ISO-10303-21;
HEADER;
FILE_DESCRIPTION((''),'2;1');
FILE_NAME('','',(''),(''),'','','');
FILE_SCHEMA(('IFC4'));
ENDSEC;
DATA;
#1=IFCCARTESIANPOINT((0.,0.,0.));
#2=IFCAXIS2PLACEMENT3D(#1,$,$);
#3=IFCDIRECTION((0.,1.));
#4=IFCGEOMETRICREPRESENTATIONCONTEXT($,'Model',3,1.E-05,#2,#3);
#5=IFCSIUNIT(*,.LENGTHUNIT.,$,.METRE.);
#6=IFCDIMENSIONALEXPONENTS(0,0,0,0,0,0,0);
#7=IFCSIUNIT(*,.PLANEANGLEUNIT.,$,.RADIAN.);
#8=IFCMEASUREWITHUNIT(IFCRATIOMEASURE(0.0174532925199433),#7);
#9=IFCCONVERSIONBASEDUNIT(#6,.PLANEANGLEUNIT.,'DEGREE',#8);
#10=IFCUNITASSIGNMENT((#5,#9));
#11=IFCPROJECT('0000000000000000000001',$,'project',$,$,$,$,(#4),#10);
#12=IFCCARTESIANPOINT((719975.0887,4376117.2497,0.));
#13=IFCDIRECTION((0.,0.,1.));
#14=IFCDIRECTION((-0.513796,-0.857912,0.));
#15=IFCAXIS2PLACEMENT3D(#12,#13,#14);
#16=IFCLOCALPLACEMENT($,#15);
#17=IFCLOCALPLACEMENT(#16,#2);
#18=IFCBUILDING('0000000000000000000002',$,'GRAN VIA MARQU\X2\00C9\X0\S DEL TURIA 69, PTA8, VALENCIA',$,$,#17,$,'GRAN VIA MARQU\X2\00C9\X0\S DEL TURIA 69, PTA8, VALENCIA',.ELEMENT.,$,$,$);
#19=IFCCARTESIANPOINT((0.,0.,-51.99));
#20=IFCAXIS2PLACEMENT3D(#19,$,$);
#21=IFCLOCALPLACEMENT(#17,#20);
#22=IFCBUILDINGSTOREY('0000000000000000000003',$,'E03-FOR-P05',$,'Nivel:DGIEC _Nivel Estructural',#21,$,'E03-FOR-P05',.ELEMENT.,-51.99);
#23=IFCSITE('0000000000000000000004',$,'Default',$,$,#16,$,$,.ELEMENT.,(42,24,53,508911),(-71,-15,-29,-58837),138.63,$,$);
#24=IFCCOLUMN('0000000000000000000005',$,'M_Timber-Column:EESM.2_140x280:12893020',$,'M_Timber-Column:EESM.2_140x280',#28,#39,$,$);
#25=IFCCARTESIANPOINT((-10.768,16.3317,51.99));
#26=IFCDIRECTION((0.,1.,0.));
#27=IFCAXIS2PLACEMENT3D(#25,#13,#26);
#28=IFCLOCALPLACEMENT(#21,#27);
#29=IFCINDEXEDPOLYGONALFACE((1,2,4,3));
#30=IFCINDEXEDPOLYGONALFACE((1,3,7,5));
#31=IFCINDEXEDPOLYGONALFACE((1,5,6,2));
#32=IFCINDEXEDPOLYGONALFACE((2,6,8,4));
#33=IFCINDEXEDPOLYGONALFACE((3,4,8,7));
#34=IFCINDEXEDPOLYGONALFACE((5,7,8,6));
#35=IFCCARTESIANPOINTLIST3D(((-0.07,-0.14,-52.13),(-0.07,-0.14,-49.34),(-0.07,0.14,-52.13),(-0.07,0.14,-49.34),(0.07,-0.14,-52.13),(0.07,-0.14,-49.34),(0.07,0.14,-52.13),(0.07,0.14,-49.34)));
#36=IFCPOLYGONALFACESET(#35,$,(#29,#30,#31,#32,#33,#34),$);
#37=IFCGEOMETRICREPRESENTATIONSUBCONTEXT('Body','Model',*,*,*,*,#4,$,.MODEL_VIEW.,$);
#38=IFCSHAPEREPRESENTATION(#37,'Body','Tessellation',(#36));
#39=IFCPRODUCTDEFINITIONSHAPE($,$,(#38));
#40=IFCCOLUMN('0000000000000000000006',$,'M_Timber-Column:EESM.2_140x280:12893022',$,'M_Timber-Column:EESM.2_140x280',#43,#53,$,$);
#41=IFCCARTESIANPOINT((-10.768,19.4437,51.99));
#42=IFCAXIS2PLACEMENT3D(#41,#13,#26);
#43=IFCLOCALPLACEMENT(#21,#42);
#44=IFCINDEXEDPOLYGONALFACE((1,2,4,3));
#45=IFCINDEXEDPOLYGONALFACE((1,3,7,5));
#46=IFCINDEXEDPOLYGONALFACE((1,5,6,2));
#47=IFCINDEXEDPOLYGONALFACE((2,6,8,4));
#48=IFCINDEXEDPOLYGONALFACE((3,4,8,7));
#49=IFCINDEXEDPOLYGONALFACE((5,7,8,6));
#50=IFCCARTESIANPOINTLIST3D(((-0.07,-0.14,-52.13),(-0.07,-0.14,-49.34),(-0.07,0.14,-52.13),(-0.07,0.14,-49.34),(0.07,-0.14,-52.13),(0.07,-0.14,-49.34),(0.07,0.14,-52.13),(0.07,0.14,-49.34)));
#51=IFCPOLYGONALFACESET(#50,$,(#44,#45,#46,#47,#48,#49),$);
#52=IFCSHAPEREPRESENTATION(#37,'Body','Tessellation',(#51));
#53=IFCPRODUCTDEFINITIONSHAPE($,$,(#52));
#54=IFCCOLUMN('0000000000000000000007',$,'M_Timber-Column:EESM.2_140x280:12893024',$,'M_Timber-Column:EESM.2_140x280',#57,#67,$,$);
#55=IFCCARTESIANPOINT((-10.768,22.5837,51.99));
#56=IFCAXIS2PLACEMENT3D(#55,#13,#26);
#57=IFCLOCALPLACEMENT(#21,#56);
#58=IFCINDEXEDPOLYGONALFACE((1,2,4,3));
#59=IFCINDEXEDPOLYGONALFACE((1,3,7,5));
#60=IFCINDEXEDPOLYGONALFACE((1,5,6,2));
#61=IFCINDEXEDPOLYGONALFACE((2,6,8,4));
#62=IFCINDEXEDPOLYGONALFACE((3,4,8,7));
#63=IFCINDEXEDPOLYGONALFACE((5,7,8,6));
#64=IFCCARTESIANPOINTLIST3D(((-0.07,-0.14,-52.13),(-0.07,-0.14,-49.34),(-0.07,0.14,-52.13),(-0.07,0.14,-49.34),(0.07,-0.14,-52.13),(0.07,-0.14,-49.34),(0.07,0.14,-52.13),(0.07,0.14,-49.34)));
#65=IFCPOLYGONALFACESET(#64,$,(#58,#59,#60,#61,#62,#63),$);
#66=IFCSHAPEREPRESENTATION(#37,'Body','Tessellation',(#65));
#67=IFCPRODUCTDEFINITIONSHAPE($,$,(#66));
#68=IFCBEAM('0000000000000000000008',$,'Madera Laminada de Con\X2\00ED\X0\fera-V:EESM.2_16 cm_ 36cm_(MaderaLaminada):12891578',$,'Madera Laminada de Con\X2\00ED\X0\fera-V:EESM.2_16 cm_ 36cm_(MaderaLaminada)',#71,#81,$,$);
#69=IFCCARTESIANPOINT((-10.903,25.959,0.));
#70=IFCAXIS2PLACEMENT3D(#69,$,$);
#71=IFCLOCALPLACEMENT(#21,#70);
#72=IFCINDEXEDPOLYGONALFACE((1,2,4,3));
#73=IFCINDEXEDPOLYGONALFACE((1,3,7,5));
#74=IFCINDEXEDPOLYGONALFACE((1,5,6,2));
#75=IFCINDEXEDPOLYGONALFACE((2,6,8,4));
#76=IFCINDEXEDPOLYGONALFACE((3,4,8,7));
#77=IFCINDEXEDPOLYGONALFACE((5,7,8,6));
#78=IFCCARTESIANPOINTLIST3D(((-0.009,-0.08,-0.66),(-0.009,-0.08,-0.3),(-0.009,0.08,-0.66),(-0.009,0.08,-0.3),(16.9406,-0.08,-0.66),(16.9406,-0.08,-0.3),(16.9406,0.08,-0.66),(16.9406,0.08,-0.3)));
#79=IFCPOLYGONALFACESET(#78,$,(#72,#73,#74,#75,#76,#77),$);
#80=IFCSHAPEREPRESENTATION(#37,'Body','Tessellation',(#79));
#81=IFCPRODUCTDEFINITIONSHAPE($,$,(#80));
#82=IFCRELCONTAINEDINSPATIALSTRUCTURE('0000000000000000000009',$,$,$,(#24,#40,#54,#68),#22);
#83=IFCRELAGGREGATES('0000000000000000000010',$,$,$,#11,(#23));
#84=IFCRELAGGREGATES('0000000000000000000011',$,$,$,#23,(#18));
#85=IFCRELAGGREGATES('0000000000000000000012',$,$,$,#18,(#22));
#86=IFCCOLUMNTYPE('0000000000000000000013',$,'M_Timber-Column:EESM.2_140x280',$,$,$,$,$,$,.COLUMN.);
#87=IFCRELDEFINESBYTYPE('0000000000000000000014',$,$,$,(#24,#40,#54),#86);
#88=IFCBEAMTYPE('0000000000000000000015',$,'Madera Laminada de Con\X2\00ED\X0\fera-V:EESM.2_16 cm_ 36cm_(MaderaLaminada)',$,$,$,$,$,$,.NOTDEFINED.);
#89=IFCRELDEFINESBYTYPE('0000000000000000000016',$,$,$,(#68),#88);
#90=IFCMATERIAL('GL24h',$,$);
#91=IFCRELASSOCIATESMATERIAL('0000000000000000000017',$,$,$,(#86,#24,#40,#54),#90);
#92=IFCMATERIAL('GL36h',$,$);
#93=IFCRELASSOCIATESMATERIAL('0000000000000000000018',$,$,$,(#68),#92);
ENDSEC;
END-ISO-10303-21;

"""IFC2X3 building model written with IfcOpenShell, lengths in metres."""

from ifc_helpers import new_model, entity, si_unit, converted_unit, direction, frame, frame_2d, origin, origin_2d_with_axis, place, context, subcontext, project, spatial, rectangle, extrude, source, transform, mapped, material, type_object, type_shapes, element, save


model = new_model("IFC2X3")

# Units and contexts
model_context = context("Model", 3, precision=1e-05, world=origin(), true_north=direction((0.0, 1.0)))
body_context = subcontext(model_context, "Body", "Model", "MODEL_VIEW")
ifc_project = project(units=[si_unit("LENGTHUNIT", "METRE"), converted_unit("PLANEANGLEUNIT", "DEGREE", entity("IfcRatioMeasure", 0.0174532925199433), si_unit("PLANEANGLEUNIT", "RADIAN"), dimensions=[0, 0, 0, 0, 0, 0, 0])], contexts=[model_context])

# Site, building, storey
site_placement = place(None, frame((719975.0887, 4376117.2497, 0.0), z_axis=(0.0, 0.0, 1.0), x_axis=(-0.513796, -0.857912, 0.0)))
site = spatial("IfcSite", under=ifc_project, at=site_placement, Name="Default", CompositionType="ELEMENT", RefLatitude=(42, 24, 53, 508911), RefLongitude=(-71, -15, -29, -58837), RefElevation=138.63)
building_placement = place(site_placement, origin())
building = spatial("IfcBuilding", under=site, at=building_placement, Name="GRAN VIA MARQUÉS DEL TURIA 69, PTA8, VALENCIA", LongName="GRAN VIA MARQUÉS DEL TURIA 69, PTA8, VALENCIA", CompositionType="ELEMENT")
storey_placement = place(building_placement, frame((0.0, 0.0, -51.99)))
storey = spatial("IfcBuildingStorey", under=building, at=storey_placement, Name="E03-FOR-P05", ObjectType="Nivel:DGIEC _Nivel Estructural", LongName="E03-FOR-P05", CompositionType="ELEMENT", Elevation=-51.99)

# Columns
ifc_material_1 = material(Name="GL24h")
column_type_1 = type_object("IfcColumnType", Name="M_Timber-Column:EESM.2_140x280", PredefinedType="COLUMN", material=ifc_material_1)
shared_shape_1 = source(origin(), body_context, "Body", "SweptSolid", [
    extrude(rectangle(XDim=0.28, YDim=0.14, at=origin_2d_with_axis()), frame((0.0, 0.0, -52.13), z_axis=(0.0, 0.0, 1.0), x_axis=(0.0, -1.0, 0.0)), (0.0, 0.0, 1.0), 2.79),
])
type_shapes(column_type_1, [shared_shape_1])
for number, where, z_axis, x_axis, name in (
    (1, (-10.768, 16.3317, 51.99), (0.0, 0.0, 1.0), (0.0, 1.0, 0.0), "M_Timber-Column:EESM.2_140x280:12893020"),
    (2, (-10.768, 19.4437, 51.99), (0.0, 0.0, 1.0), (0.0, 1.0, 0.0), "M_Timber-Column:EESM.2_140x280:12893022"),
    (3, (-10.768, 22.5837, 51.99), (0.0, 0.0, 1.0), (0.0, 1.0, 0.0), "M_Timber-Column:EESM.2_140x280:12893024"),
):
    element("IfcColumn", number, at=place(storey_placement, frame(where, z_axis=z_axis, x_axis=x_axis)), inside=storey, type_object=column_type_1, material=ifc_material_1, Name=name, ObjectType="M_Timber-Column:EESM.2_140x280", context=body_context, shape_type="MappedRepresentation", body=[
        mapped(shared_shape_1, transform((0.0, 0.0, 0.0), scale=1.0)),
    ])

# Beam
ifc_material_2 = material(Name="GL36h")
beam_type_1 = type_object("IfcBeamType", Name="Madera Laminada de Conífera-V:EESM.2_16 cm_ 36cm_(MaderaLaminada)", PredefinedType="NOTDEFINED")
beam_1_placement = place(storey_placement, frame((-10.903, 25.959, 0.0)))
element("IfcBeam", 4, at=beam_1_placement, inside=storey, type_object=beam_type_1, material=ifc_material_2, Name="Madera Laminada de Conífera-V:EESM.2_16 cm_ 36cm_(MaderaLaminada):12891578", ObjectType="Madera Laminada de Conífera-V:EESM.2_16 cm_ 36cm_(MaderaLaminada)", context=body_context, shape_type="SweptSolid", body=[
    extrude(rectangle(XDim=0.36, YDim=0.16, at=frame_2d((0.0, 0.0), x_axis=(1.0, 0.0))), frame((-0.009, 0.0, -0.48), z_axis=(1.0, 0.0, 0.0), x_axis=(0.0, 0.0, -1.0)), (0.0, 0.0, 1.0), 16.9496),
])

save(model, "model.ifc")
